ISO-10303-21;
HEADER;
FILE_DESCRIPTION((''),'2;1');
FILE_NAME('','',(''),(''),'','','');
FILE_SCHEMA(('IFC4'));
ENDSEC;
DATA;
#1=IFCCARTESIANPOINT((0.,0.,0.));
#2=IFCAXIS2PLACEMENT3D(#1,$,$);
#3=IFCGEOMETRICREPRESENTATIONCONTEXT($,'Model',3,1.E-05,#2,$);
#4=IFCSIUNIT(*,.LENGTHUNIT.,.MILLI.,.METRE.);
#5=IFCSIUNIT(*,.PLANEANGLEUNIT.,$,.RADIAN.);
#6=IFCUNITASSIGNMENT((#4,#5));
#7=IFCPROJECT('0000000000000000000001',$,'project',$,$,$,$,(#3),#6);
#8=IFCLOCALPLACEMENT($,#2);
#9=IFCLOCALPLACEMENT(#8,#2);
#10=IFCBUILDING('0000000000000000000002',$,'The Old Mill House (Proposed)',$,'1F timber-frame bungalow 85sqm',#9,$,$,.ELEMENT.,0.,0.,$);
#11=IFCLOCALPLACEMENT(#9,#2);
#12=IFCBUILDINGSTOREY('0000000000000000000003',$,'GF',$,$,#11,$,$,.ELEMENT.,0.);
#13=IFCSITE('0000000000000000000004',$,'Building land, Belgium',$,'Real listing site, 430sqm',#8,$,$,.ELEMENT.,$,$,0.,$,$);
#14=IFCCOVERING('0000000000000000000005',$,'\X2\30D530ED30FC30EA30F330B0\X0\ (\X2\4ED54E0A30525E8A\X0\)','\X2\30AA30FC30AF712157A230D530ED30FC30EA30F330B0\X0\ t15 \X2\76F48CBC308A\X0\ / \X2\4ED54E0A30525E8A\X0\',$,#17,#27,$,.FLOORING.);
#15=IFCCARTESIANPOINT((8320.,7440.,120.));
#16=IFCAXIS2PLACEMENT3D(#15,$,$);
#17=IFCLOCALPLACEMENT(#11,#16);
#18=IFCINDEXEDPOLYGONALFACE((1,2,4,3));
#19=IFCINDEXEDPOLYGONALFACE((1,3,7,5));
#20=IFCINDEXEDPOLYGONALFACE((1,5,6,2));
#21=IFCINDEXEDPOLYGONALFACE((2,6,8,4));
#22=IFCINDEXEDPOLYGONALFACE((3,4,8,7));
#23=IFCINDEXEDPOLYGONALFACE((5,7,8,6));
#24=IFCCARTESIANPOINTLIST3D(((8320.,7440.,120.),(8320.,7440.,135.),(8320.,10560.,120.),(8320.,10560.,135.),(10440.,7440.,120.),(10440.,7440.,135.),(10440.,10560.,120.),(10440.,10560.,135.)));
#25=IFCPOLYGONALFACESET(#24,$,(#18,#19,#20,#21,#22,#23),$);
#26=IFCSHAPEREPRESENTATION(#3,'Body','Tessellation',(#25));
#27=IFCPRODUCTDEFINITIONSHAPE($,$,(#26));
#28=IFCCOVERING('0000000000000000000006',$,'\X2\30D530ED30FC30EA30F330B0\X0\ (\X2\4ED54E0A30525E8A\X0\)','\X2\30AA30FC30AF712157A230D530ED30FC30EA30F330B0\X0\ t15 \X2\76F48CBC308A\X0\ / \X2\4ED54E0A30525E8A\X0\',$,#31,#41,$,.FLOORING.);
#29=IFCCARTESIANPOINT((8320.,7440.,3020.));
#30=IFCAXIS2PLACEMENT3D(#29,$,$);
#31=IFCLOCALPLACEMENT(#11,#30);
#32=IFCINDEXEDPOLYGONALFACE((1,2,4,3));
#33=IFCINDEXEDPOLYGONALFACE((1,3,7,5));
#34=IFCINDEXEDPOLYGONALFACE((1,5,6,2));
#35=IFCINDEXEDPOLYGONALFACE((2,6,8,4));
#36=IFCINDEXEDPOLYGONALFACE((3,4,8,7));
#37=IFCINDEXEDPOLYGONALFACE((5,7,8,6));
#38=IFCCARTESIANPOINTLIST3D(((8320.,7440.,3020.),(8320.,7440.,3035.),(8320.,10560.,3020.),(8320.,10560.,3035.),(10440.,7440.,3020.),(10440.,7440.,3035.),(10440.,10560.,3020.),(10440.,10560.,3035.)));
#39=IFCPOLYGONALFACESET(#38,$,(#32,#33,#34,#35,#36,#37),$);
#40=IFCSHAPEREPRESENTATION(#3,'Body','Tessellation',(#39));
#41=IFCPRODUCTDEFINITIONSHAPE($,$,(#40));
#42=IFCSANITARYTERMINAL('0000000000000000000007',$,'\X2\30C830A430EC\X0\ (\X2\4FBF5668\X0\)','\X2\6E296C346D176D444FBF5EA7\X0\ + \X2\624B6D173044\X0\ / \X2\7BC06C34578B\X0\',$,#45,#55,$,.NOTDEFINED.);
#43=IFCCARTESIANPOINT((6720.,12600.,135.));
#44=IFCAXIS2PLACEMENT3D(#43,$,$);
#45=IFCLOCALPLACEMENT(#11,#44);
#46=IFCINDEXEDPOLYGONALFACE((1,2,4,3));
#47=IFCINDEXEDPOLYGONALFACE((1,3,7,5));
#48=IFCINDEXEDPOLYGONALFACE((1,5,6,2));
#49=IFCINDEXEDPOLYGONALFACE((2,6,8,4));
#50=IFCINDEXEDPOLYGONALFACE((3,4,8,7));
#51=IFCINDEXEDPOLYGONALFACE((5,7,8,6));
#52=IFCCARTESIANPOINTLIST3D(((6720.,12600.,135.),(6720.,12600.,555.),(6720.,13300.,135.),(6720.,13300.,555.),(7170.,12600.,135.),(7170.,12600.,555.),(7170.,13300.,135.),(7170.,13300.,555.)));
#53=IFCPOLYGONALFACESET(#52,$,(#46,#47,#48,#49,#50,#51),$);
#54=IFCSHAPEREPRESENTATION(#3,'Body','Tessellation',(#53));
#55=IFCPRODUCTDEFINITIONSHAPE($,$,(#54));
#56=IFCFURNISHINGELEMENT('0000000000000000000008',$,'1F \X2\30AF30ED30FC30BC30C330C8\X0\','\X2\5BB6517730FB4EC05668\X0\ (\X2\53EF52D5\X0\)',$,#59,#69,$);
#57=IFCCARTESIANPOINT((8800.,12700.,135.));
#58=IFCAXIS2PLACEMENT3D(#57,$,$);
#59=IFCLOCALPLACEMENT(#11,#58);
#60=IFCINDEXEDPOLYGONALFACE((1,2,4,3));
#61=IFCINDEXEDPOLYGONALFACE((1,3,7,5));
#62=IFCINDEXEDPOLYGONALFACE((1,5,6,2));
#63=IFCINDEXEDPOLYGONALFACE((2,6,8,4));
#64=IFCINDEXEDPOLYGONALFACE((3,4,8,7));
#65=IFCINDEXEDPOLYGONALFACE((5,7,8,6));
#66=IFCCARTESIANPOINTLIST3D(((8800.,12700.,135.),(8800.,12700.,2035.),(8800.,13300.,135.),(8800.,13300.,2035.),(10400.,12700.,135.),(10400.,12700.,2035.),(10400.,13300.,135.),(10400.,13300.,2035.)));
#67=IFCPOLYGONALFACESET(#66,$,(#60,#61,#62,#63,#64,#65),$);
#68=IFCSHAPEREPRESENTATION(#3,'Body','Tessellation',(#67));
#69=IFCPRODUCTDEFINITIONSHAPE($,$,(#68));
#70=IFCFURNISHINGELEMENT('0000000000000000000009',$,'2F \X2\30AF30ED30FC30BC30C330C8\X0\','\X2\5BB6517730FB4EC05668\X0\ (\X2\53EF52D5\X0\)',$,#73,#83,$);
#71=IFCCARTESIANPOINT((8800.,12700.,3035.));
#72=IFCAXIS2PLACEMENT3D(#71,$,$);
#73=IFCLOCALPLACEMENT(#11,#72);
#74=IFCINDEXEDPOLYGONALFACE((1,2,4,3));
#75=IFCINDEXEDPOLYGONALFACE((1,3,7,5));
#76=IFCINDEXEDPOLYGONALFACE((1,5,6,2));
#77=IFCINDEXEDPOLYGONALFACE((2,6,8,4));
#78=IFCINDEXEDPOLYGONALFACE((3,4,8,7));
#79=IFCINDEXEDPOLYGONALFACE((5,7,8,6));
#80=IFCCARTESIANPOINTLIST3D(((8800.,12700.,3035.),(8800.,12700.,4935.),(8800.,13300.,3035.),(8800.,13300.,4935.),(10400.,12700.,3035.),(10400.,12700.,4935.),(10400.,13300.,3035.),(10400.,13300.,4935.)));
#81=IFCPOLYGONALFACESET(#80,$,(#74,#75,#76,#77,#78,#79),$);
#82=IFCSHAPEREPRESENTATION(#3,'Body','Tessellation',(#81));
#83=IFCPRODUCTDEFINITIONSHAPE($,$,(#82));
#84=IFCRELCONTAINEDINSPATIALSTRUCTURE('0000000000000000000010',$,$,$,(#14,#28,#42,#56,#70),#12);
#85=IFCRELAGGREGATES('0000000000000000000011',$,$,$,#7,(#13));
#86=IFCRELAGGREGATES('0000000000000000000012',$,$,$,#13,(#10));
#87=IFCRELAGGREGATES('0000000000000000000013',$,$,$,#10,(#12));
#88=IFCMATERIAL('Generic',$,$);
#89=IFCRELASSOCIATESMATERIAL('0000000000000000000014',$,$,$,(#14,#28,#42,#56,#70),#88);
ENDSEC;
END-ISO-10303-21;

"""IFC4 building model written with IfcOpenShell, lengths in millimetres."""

from ifc_helpers import new_model, si_unit, frame, frame_2d, origin, place, context, project, spatial, rectangle, extrude, material, element, save


model = new_model("IFC4")

# Units and contexts
model_context = context("Model", 3, precision=1e-05, world=origin())
ifc_project = project(units=[si_unit("LENGTHUNIT", "METRE", prefix="MILLI"), si_unit("PLANEANGLEUNIT", "RADIAN")], contexts=[model_context])

# Site, building, storey
site_placement = place(None, origin())
site = spatial("IfcSite", under=ifc_project, at=site_placement, Name="Building land, Belgium", ObjectType="Real listing site, 430sqm", CompositionType="ELEMENT", RefElevation=0.0)
building_placement = place(site_placement, origin())
building = spatial("IfcBuilding", under=site, at=building_placement, Name="The Old Mill House (Proposed)", ObjectType="1F timber-frame bungalow 85sqm", CompositionType="ELEMENT", ElevationOfRefHeight=0.0, ElevationOfTerrain=0.0)
storey_placement = place(building_placement, origin())
storey = spatial("IfcBuildingStorey", under=building, at=storey_placement, Name="GF", CompositionType="ELEMENT", Elevation=0.0)

# Shared definitions
ifc_material_1 = material(Name="Generic")

# Coverings
covering_1_placement = place(storey_placement, frame((8320.0, 7440.0, 120.0)))
element("IfcCovering", 1, at=covering_1_placement, inside=storey, material=ifc_material_1, Name="フローリング (仕上げ床)", Description="オーク無垢フローリング t15 直貼り / 仕上げ床", PredefinedType="FLOORING", context=model_context, shape_type="SweptSolid", body=[
    extrude(rectangle(XDim=2120.0, YDim=3120.0, at=frame_2d((1060.0, 1560.0))), frame((8320.0, 7440.0, 120.0)), (0.0, 0.0, 1.0), 15.0),
])
covering_2_placement = place(storey_placement, frame((8320.0, 7440.0, 3020.0)))
element("IfcCovering", 2, at=covering_2_placement, inside=storey, material=ifc_material_1, Name="フローリング (仕上げ床)", Description="オーク無垢フローリング t15 直貼り / 仕上げ床", PredefinedType="FLOORING", context=model_context, shape_type="SweptSolid", body=[
    extrude(rectangle(XDim=2120.0, YDim=3120.0, at=frame_2d((1060.0, 1560.0))), frame((8320.0, 7440.0, 3020.0)), (0.0, 0.0, 1.0), 15.0),
])

# Sanitary terminal
sanitary_terminal_placement = place(storey_placement, frame((6720.0, 12600.0, 135.0)))
element("IfcSanitaryTerminal", 3, at=sanitary_terminal_placement, inside=storey, material=ifc_material_1, Name="トイレ (便器)", Description="温水洗浄便座 + 手洗い / 節水型", PredefinedType="NOTDEFINED", context=model_context, shape_type="SweptSolid", body=[
    extrude(rectangle(XDim=450.0, YDim=700.0, at=frame_2d((225.0, 350.0))), frame((6720.0, 12600.0, 135.0)), (0.0, 0.0, 1.0), 420.0),
])

# Furnishing elements
furnishing_1_placement = place(storey_placement, frame((8800.0, 12700.0, 135.0)))
element("IfcFurnishingElement", 4, at=furnishing_1_placement, inside=storey, material=ifc_material_1, Name="1F クローゼット", Description="家具・什器 (可動)", context=model_context, shape_type="SweptSolid", body=[
    extrude(rectangle(XDim=1600.0, YDim=600.0, at=frame_2d((800.0, 300.0))), frame((8800.0, 12700.0, 135.0)), (0.0, 0.0, 1.0), 1900.0),
])
furnishing_2_placement = place(storey_placement, frame((8800.0, 12700.0, 3035.0)))
element("IfcFurnishingElement", 5, at=furnishing_2_placement, inside=storey, material=ifc_material_1, Name="2F クローゼット", Description="家具・什器 (可動)", context=model_context, shape_type="SweptSolid", body=[
    extrude(rectangle(XDim=1600.0, YDim=600.0, at=frame_2d((800.0, 300.0))), frame((8800.0, 12700.0, 3035.0)), (0.0, 0.0, 1.0), 1900.0),
])

save(model, "model.ifc")
